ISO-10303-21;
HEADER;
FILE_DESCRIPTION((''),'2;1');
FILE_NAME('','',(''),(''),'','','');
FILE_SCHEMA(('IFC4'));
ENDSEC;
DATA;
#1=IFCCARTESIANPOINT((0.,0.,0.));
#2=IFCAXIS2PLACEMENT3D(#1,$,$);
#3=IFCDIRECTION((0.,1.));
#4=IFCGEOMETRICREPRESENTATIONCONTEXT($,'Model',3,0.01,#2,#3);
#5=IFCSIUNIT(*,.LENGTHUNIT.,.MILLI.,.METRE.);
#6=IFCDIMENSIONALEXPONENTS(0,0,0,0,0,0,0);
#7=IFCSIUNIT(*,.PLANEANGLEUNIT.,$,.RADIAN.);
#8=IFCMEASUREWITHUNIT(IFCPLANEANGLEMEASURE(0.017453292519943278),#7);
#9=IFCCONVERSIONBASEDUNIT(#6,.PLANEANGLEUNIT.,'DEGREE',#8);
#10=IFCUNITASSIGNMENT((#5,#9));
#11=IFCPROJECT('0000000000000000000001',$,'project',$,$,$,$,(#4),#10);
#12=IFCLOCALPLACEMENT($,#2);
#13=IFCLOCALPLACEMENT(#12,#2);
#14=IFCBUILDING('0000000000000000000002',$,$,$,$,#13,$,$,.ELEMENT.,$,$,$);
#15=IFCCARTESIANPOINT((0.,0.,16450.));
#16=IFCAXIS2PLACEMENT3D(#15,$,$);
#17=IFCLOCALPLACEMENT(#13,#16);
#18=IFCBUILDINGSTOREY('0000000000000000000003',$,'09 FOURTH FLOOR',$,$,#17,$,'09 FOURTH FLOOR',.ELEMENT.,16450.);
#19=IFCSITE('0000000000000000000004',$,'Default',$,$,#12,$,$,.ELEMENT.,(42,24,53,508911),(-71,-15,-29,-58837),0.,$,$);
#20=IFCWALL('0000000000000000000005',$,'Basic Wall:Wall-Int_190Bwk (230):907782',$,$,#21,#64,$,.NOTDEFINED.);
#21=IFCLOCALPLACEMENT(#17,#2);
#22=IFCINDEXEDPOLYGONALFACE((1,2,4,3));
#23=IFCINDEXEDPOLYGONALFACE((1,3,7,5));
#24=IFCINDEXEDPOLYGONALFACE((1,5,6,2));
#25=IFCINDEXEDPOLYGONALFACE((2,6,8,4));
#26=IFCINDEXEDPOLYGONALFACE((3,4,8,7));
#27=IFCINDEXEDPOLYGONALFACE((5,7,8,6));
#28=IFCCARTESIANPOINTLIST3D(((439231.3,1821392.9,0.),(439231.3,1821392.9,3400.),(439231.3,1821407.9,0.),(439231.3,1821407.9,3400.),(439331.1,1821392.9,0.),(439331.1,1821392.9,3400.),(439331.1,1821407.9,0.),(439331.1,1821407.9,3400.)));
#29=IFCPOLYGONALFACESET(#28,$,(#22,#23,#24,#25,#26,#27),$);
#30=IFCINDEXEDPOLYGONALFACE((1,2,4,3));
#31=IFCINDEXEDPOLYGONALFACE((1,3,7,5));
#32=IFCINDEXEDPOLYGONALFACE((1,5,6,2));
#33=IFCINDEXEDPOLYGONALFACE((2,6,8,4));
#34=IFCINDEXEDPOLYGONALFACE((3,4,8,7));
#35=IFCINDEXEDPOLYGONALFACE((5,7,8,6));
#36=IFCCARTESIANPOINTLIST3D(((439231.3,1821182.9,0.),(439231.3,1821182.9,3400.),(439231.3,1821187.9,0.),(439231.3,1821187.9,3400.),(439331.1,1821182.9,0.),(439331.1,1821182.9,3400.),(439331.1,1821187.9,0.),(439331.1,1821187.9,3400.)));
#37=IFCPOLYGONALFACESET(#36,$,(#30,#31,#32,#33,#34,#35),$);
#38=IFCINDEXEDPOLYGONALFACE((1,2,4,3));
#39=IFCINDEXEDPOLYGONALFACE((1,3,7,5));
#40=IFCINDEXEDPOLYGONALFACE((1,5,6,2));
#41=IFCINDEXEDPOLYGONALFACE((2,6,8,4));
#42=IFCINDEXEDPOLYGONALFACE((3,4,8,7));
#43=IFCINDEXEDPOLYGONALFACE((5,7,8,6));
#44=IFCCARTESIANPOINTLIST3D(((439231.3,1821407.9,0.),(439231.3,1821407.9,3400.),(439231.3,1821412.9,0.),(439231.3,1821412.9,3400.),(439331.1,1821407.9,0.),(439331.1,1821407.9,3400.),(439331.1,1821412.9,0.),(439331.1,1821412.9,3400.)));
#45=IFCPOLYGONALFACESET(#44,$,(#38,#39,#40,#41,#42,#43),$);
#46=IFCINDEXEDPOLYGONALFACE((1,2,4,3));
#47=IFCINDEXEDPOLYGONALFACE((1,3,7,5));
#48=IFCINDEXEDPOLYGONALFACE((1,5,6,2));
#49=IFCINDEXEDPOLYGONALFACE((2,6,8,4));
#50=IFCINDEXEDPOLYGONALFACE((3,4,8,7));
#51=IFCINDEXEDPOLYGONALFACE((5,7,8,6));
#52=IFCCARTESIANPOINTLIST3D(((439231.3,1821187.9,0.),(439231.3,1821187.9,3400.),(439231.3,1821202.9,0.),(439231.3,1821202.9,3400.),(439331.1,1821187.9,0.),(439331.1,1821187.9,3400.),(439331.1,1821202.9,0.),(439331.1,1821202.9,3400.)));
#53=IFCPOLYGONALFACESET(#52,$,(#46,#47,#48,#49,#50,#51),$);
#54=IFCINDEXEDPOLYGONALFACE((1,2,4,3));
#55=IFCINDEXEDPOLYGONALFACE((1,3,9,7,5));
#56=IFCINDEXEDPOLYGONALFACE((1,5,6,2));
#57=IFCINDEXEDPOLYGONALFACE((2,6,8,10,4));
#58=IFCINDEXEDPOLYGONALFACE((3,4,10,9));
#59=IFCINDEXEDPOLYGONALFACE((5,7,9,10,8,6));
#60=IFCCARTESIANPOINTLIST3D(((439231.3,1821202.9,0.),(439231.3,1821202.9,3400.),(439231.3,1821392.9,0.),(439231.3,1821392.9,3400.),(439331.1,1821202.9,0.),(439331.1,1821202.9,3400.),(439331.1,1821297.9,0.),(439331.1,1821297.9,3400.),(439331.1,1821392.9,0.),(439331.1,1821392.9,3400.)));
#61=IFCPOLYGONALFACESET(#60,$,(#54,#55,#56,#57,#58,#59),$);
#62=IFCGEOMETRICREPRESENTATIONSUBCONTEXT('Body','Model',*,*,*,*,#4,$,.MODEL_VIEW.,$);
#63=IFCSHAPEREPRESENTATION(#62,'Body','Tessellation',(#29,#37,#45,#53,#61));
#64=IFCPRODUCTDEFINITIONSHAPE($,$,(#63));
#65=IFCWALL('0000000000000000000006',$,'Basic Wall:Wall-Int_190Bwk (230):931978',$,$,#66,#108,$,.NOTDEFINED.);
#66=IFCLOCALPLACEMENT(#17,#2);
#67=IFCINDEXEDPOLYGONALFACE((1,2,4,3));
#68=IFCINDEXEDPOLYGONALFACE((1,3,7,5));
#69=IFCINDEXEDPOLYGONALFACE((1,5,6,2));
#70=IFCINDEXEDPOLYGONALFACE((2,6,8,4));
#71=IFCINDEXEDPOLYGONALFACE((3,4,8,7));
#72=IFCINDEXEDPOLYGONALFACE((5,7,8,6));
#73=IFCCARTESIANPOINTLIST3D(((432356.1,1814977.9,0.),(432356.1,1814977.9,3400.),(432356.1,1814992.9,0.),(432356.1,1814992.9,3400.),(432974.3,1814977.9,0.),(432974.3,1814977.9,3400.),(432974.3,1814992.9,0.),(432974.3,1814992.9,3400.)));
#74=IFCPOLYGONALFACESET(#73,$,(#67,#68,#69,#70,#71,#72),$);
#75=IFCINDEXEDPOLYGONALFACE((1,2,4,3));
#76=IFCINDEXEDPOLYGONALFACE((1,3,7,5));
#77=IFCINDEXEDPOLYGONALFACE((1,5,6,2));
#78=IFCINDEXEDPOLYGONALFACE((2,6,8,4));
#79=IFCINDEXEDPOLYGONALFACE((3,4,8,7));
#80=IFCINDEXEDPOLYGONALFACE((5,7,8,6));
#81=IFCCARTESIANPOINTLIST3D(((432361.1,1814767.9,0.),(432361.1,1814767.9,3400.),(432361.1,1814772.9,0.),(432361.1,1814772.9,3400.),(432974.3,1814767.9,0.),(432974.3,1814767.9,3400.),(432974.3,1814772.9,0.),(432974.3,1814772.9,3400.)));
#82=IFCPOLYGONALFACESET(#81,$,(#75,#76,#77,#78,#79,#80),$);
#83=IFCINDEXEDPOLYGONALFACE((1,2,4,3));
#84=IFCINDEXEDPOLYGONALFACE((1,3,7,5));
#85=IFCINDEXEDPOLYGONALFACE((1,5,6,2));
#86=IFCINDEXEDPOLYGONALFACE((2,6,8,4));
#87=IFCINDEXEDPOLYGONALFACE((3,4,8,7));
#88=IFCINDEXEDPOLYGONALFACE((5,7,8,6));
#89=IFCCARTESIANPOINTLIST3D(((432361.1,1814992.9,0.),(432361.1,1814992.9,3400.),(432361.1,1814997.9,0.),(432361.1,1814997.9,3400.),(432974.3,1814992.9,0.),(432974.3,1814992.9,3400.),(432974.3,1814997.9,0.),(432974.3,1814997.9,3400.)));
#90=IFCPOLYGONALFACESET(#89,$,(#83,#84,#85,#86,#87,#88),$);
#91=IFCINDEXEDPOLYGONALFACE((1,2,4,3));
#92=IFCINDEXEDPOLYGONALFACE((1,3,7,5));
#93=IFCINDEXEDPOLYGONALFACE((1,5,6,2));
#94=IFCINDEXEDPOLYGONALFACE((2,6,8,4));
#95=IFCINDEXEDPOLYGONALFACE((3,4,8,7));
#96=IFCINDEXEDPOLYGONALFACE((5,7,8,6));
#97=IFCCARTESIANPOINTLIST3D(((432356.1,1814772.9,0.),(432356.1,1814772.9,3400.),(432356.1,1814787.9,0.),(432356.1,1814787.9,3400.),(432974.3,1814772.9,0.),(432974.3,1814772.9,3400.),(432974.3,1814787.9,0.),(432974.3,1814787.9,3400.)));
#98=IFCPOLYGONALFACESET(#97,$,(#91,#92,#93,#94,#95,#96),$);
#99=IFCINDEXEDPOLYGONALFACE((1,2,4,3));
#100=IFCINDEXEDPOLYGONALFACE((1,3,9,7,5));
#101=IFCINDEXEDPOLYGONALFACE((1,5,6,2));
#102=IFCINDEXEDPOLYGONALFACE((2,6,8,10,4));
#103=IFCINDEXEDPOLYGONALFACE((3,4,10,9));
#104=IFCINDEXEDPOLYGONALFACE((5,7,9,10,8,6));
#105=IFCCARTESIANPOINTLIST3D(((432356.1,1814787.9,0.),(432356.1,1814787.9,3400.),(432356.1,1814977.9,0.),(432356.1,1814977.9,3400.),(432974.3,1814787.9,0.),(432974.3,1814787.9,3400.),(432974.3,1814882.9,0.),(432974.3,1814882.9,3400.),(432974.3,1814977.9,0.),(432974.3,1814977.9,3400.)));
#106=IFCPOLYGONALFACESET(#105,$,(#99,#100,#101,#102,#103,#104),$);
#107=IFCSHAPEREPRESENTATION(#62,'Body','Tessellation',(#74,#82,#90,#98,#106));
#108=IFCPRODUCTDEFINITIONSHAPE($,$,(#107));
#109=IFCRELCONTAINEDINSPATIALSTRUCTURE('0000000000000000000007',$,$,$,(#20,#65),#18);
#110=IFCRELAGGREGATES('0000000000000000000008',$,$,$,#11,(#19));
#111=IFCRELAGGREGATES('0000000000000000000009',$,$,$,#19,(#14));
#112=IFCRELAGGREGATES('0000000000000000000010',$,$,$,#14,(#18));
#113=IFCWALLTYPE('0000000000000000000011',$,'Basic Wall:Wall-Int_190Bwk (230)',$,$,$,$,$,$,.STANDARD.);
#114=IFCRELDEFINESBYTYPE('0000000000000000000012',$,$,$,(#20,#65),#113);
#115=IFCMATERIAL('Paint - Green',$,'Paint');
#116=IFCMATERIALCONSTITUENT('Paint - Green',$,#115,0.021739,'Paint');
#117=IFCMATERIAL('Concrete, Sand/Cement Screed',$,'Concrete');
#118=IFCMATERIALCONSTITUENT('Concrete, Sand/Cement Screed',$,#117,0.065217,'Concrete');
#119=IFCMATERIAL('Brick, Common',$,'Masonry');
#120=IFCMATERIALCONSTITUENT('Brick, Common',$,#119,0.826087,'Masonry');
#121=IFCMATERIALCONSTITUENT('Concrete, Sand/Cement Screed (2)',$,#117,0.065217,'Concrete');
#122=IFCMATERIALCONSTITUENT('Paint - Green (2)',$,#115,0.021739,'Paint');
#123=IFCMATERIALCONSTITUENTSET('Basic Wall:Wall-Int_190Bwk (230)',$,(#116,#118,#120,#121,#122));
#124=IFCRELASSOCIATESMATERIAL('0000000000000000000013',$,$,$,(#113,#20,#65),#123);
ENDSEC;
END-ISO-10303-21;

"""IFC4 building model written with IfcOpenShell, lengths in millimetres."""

from ifc_helpers import new_model, entity, si_unit, converted_unit, direction, frame, origin, place, context, subcontext, project, spatial, indexed_curve, outline, extrude, material, constituent, constituent_set, type_object, element, save


model = new_model("IFC4")

# Units and contexts
model_context = context("Model", 3, precision=0.01, world=origin(), true_north=direction((0.0, 1.0)))
body_context = subcontext(model_context, "Body", "Model", "MODEL_VIEW")
ifc_project = project(units=[si_unit("LENGTHUNIT", "METRE", prefix="MILLI"), converted_unit("PLANEANGLEUNIT", "DEGREE", entity("IfcPlaneAngleMeasure", 0.017453292519943278), si_unit("PLANEANGLEUNIT", "RADIAN"), dimensions=[0, 0, 0, 0, 0, 0, 0])], contexts=[model_context])

# Site, building, storey
site_placement = place(None, origin())
site = spatial("IfcSite", under=ifc_project, at=site_placement, Name="Default", CompositionType="ELEMENT", RefLatitude=(42, 24, 53, 508911), RefLongitude=(-71, -15, -29, -58837), RefElevation=0.0)
building_placement = place(site_placement, origin())
building = spatial("IfcBuilding", under=site, at=building_placement, CompositionType="ELEMENT")
storey_placement = place(building_placement, frame((0.0, 0.0, 16450.0)))
storey = spatial("IfcBuildingStorey", under=building, at=storey_placement, Name="09 FOURTH FLOOR", LongName="09 FOURTH FLOOR", CompositionType="ELEMENT", Elevation=16450.0)

# Shared definitions
ifc_material_1 = material(Name="Concrete, Sand/Cement Screed", Category="Concrete")
ifc_material_2 = material(Name="Brick, Common", Category="Masonry")

# Shared definitions
ifc_material_3 = material(Name="Paint - Green", Category="Paint")

# Shared definitions
ifc_constituent_1 = constituent(ifc_material_3, Name="Paint - Green", Category="Paint", fraction=0.021739)
ifc_constituent_2 = constituent(ifc_material_1, Name="Concrete, Sand/Cement Screed", Category="Concrete", fraction=0.065217)
ifc_constituent_3 = constituent(ifc_material_2, Name="Brick, Common", Category="Masonry", fraction=0.826087)
ifc_constituent_4 = constituent(ifc_material_1, Name="Concrete, Sand/Cement Screed (2)", Category="Concrete", fraction=0.065217)
ifc_constituent_5 = constituent(ifc_material_3, Name="Paint - Green (2)", Category="Paint", fraction=0.021739)
ifc_constituent_set_1 = constituent_set(constituents=[ifc_constituent_1, ifc_constituent_2, ifc_constituent_3, ifc_constituent_4, ifc_constituent_5], Name="Basic Wall:Wall-Int_190Bwk (230)")
wall_type_1 = type_object("IfcWallType", Name="Basic Wall:Wall-Int_190Bwk (230)", PredefinedType="STANDARD", material=ifc_constituent_set_1)

# Walls
wall_1_placement = place(storey_placement, frame((439231.3, 1821297.9, 0.0)))
element("IfcWall", 1, at=wall_1_placement, inside=storey, type_object=wall_type_1, material=ifc_constituent_set_1, Name="Basic Wall:Wall-Int_190Bwk (230):907782", PredefinedType="NOTDEFINED", context=body_context, shape_type="SweptSolid", body=[
    extrude(outline(indexed_curve([(-49.9, -7.5), (49.9, -7.5), (49.9, 7.5), (-49.9, 7.5), (-49.9, -7.5)], self_intersect=False)), frame((49.9, 102.5, 0.0)), (0.0, 0.0, 1.0), 3400.0),
    extrude(outline(indexed_curve([(-2.5, -49.9), (2.5, -49.9), (2.5, 49.9), (-2.5, 49.9), (-2.5, -49.9)], self_intersect=False)), frame((49.9, -112.5, 0.0), z_axis=(0.0, 0.0, 1.0), x_axis=(0.0, 1.0, 0.0)), (0.0, 0.0, 1.0), 3400.0),
    extrude(outline(indexed_curve([(-2.5, -49.9), (2.5, -49.9), (2.5, 49.9), (-2.5, 49.9), (-2.5, -49.9)], self_intersect=False)), frame((49.9, 112.5, 0.0), z_axis=(0.0, 0.0, 1.0), x_axis=(0.0, -1.0, 0.0)), (0.0, 0.0, 1.0), 3400.0),
    extrude(outline(indexed_curve([(-49.9, -7.5), (49.9, -7.5), (49.9, 7.5), (-49.9, 7.5), (-49.9, -7.5)], self_intersect=False)), frame((49.9, -102.5, 0.0)), (0.0, 0.0, 1.0), 3400.0),
    extrude(outline(indexed_curve([(-59.9, -95.0), (39.9, -95.0), (39.9, 0.0), (39.9, 95.0), (-59.9, 95.0), (-59.9, -95.0)], self_intersect=False)), frame((59.9, 0.0, 0.0)), (0.0, 0.0, 1.0), 3400.0),
])
wall_2_placement = place(storey_placement, frame((432361.1, 1814882.9, 0.0)))
element("IfcWall", 2, at=wall_2_placement, inside=storey, type_object=wall_type_1, material=ifc_constituent_set_1, Name="Basic Wall:Wall-Int_190Bwk (230):931978", PredefinedType="NOTDEFINED", context=body_context, shape_type="SweptSolid", body=[
    extrude(outline(indexed_curve([(-309.1, -7.5), (309.1, -7.5), (309.1, 7.5), (-309.1, 7.5), (-309.1, -7.5)], self_intersect=False)), frame((304.1, 102.5, 0.0)), (0.0, 0.0, 1.0), 3400.0),
    extrude(outline(indexed_curve([(-2.5, -306.6), (2.5, -306.6), (2.5, 306.6), (-2.5, 306.6), (-2.5, -306.6)], self_intersect=False)), frame((306.6, -112.5, 0.0), z_axis=(0.0, 0.0, 1.0), x_axis=(0.0, 1.0, 0.0)), (0.0, 0.0, 1.0), 3400.0),
    extrude(outline(indexed_curve([(-2.5, -306.6), (2.5, -306.6), (2.5, 306.6), (-2.5, 306.6), (-2.5, -306.6)], self_intersect=False)), frame((306.6, 112.5, 0.0), z_axis=(0.0, 0.0, 1.0), x_axis=(0.0, -1.0, 0.0)), (0.0, 0.0, 1.0), 3400.0),
    extrude(outline(indexed_curve([(-309.1, -7.5), (309.1, -7.5), (309.1, 7.5), (-309.1, 7.5), (-309.1, -7.5)], self_intersect=False)), frame((304.1, -102.5, 0.0)), (0.0, 0.0, 1.0), 3400.0),
    extrude(outline(indexed_curve([(-370.9, -95.0), (247.3, -95.0), (247.3, 0.0), (247.3, 95.0), (-370.9, 95.0), (-370.9, -95.0)], self_intersect=False)), frame((365.9, 0.0, 0.0)), (0.0, 0.0, 1.0), 3400.0),
])

save(model, "model.ifc")
